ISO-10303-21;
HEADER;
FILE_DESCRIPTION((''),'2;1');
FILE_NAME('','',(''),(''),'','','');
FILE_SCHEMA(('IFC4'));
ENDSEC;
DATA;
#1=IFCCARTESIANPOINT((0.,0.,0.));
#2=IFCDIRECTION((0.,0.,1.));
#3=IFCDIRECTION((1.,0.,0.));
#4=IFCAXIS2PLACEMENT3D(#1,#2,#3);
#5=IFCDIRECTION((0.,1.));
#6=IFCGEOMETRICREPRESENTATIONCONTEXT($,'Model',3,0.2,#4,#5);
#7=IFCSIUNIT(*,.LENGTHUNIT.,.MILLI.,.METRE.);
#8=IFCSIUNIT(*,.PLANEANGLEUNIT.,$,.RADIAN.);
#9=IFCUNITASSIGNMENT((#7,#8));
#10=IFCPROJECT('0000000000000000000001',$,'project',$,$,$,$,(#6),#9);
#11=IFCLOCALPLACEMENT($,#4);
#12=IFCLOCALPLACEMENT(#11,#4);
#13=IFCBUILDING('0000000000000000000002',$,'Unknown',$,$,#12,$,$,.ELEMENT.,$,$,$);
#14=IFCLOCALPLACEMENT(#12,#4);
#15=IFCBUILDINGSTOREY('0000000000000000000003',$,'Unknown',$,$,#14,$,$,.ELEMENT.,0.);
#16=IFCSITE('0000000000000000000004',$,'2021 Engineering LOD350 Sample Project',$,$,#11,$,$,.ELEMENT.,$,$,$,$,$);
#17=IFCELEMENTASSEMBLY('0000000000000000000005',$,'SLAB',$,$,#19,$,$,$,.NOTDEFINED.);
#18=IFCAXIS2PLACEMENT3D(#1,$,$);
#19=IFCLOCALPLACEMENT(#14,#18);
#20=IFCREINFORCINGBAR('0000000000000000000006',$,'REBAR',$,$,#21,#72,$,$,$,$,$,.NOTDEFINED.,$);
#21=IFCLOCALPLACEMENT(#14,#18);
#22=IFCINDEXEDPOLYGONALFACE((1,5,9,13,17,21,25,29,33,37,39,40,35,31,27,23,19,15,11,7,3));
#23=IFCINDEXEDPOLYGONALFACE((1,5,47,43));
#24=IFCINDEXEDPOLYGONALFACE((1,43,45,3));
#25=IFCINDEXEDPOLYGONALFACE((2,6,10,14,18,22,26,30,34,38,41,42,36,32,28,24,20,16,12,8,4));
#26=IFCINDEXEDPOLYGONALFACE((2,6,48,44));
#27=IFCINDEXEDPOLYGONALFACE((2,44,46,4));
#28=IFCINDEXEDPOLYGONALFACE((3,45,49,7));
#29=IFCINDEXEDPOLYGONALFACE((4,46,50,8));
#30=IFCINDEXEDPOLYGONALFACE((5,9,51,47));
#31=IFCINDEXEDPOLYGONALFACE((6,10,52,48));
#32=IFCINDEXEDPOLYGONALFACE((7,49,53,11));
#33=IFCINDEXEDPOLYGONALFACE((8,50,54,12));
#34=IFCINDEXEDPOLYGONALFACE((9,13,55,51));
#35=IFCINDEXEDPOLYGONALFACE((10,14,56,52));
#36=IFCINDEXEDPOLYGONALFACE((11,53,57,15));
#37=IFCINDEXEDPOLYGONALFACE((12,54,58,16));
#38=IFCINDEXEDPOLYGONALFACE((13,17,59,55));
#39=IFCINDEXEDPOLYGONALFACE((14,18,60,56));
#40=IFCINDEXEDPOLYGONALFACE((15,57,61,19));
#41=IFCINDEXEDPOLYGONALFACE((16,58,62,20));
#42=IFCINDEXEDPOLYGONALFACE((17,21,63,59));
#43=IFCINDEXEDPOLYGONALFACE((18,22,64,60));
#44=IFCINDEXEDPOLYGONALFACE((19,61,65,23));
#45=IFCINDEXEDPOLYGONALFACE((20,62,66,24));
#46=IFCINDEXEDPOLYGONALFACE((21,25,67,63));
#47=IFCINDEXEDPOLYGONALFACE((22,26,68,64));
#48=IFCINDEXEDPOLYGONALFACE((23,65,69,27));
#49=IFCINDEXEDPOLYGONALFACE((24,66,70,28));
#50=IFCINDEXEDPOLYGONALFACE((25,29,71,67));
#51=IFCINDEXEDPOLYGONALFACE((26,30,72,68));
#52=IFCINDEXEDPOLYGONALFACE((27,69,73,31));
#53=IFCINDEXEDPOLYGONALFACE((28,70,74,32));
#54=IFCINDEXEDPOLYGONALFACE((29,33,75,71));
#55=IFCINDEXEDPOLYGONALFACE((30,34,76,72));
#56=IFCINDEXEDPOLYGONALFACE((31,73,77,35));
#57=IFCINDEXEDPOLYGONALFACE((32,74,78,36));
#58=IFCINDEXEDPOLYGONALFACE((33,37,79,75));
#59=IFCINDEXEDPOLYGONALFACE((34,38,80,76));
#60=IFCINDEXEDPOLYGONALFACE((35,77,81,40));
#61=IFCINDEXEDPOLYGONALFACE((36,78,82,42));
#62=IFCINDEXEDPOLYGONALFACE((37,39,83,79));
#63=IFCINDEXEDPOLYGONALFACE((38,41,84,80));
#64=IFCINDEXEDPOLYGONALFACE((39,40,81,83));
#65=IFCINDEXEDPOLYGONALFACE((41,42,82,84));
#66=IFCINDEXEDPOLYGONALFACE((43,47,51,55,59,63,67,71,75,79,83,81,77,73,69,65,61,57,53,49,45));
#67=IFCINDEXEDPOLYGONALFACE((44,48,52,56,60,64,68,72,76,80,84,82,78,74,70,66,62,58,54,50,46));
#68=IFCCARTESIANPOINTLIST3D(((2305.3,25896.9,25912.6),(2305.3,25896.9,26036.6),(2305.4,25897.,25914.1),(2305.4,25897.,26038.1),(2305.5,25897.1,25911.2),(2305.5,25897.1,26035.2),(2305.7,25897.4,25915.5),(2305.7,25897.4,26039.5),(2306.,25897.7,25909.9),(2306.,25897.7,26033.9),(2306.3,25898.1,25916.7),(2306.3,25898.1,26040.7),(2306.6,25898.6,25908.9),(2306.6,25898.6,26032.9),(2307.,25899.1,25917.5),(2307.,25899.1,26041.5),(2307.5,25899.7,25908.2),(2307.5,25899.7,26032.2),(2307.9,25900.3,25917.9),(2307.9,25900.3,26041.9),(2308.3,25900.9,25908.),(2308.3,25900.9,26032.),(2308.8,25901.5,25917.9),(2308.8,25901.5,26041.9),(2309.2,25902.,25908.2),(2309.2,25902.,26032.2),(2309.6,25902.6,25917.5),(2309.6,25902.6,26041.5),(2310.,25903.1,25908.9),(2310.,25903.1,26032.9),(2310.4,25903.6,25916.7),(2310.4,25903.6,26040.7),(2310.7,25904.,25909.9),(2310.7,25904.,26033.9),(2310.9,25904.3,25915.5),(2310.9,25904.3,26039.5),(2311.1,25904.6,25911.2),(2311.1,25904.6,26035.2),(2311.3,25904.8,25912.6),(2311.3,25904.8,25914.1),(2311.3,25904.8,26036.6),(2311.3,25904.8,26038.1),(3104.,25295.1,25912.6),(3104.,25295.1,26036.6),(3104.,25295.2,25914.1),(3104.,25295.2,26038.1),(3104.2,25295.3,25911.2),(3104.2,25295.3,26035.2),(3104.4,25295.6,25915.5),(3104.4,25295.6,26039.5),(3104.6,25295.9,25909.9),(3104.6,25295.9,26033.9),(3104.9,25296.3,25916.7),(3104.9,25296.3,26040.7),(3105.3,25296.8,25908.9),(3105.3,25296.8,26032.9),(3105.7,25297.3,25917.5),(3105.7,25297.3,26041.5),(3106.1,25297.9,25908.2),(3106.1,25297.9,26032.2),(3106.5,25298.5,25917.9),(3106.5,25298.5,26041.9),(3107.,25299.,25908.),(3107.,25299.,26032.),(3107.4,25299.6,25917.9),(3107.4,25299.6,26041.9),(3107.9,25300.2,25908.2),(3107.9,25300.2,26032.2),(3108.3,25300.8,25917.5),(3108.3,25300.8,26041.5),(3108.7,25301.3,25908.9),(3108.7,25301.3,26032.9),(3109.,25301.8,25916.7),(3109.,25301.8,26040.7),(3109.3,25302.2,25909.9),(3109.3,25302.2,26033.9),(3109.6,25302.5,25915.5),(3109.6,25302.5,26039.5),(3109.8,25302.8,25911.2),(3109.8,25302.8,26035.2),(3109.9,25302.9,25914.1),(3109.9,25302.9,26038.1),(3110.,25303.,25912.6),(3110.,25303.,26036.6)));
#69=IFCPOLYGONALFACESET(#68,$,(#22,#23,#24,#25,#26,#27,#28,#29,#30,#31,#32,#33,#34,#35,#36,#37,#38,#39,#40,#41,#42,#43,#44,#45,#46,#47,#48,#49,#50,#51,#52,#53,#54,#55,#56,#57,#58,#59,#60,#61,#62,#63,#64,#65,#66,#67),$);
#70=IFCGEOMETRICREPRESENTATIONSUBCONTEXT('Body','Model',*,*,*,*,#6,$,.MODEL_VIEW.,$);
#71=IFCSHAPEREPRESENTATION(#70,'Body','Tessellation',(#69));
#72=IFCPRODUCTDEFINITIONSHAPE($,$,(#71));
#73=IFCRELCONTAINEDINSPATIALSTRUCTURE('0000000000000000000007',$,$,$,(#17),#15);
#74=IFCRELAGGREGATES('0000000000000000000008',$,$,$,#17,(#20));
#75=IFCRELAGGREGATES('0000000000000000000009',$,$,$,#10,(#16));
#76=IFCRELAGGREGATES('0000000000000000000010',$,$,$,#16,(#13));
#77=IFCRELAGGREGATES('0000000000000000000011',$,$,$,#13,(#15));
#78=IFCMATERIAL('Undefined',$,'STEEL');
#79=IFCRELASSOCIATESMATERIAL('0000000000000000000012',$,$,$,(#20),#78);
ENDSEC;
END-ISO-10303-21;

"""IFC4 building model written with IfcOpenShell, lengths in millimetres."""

from ifc_helpers import new_model, entity, si_unit, direction, frame, origin_with_axes, place, context, subcontext, project, spatial, source, transform, mapped, material, element, aggregate, save


model = new_model("IFC4")

# Units and contexts
model_context = context("Model", 3, precision=0.2, world=origin_with_axes(), true_north=direction((0.0, 1.0)))
body_context = subcontext(model_context, "Body", "Model", "MODEL_VIEW")
ifc_project = project(units=[si_unit("LENGTHUNIT", "METRE", prefix="MILLI"), si_unit("PLANEANGLEUNIT", "RADIAN")], contexts=[model_context])

# Site, building, storey
site_placement = place(None, origin_with_axes())
site = spatial("IfcSite", under=ifc_project, at=site_placement, Name="2021 Engineering LOD350 Sample Project", CompositionType="ELEMENT")
building_placement = place(site_placement, origin_with_axes())
building = spatial("IfcBuilding", under=site, at=building_placement, Name="Unknown", CompositionType="ELEMENT")
storey_placement = place(building_placement, origin_with_axes())
storey = spatial("IfcBuildingStorey", under=building, at=storey_placement, Name="Unknown", CompositionType="ELEMENT", Elevation=0.0)

# Element assembly, reinforcing bar
assembly_1_placement = place(storey_placement, frame((0.0, 19194.4, 25975.0), z_axis=(0.0, 0.0, 1.0), x_axis=(0.0, -1.0, 0.0)))
assembly_1 = element("IfcElementAssembly", 1, at=assembly_1_placement, inside=storey, Name="SLAB", PredefinedType="NOTDEFINED")
ifc_material_1 = material(Name="Undefined", Category="STEEL")
shared_shape_1 = source(origin_with_axes(), body_context, "Body", "AdvancedSweptSolid", [
    entity("IfcSweptDiskSolid", entity("IfcIndexedPolyCurve", entity("IfcCartesianPointList3D", [[0.0, 0.0, 0.0], [1000.0, 0.0, 0.0]]), [entity("IfcLineIndex", [1, 2])]), 5.0),
])
reinforcing_bar_1_placement = place(assembly_1_placement, frame((-6706.5, 2308.3, -62.0), z_axis=(0.0, 0.0, -1.0), x_axis=(0.601815, 0.798635, 0.0)))
reinforcing_bar_1 = element("IfcReinforcingBar", 2, at=reinforcing_bar_1_placement, material=ifc_material_1, Name="REBAR", PredefinedType="NOTDEFINED", context=body_context, shape_type="MappedRepresentation", body=[
    mapped(shared_shape_1, transform((0.0, 0.0, 0.0))),
    mapped(shared_shape_1, transform((0.0, 0.0, -124.0))),
])

aggregate(assembly_1, [reinforcing_bar_1])

save(model, "model.ifc")
